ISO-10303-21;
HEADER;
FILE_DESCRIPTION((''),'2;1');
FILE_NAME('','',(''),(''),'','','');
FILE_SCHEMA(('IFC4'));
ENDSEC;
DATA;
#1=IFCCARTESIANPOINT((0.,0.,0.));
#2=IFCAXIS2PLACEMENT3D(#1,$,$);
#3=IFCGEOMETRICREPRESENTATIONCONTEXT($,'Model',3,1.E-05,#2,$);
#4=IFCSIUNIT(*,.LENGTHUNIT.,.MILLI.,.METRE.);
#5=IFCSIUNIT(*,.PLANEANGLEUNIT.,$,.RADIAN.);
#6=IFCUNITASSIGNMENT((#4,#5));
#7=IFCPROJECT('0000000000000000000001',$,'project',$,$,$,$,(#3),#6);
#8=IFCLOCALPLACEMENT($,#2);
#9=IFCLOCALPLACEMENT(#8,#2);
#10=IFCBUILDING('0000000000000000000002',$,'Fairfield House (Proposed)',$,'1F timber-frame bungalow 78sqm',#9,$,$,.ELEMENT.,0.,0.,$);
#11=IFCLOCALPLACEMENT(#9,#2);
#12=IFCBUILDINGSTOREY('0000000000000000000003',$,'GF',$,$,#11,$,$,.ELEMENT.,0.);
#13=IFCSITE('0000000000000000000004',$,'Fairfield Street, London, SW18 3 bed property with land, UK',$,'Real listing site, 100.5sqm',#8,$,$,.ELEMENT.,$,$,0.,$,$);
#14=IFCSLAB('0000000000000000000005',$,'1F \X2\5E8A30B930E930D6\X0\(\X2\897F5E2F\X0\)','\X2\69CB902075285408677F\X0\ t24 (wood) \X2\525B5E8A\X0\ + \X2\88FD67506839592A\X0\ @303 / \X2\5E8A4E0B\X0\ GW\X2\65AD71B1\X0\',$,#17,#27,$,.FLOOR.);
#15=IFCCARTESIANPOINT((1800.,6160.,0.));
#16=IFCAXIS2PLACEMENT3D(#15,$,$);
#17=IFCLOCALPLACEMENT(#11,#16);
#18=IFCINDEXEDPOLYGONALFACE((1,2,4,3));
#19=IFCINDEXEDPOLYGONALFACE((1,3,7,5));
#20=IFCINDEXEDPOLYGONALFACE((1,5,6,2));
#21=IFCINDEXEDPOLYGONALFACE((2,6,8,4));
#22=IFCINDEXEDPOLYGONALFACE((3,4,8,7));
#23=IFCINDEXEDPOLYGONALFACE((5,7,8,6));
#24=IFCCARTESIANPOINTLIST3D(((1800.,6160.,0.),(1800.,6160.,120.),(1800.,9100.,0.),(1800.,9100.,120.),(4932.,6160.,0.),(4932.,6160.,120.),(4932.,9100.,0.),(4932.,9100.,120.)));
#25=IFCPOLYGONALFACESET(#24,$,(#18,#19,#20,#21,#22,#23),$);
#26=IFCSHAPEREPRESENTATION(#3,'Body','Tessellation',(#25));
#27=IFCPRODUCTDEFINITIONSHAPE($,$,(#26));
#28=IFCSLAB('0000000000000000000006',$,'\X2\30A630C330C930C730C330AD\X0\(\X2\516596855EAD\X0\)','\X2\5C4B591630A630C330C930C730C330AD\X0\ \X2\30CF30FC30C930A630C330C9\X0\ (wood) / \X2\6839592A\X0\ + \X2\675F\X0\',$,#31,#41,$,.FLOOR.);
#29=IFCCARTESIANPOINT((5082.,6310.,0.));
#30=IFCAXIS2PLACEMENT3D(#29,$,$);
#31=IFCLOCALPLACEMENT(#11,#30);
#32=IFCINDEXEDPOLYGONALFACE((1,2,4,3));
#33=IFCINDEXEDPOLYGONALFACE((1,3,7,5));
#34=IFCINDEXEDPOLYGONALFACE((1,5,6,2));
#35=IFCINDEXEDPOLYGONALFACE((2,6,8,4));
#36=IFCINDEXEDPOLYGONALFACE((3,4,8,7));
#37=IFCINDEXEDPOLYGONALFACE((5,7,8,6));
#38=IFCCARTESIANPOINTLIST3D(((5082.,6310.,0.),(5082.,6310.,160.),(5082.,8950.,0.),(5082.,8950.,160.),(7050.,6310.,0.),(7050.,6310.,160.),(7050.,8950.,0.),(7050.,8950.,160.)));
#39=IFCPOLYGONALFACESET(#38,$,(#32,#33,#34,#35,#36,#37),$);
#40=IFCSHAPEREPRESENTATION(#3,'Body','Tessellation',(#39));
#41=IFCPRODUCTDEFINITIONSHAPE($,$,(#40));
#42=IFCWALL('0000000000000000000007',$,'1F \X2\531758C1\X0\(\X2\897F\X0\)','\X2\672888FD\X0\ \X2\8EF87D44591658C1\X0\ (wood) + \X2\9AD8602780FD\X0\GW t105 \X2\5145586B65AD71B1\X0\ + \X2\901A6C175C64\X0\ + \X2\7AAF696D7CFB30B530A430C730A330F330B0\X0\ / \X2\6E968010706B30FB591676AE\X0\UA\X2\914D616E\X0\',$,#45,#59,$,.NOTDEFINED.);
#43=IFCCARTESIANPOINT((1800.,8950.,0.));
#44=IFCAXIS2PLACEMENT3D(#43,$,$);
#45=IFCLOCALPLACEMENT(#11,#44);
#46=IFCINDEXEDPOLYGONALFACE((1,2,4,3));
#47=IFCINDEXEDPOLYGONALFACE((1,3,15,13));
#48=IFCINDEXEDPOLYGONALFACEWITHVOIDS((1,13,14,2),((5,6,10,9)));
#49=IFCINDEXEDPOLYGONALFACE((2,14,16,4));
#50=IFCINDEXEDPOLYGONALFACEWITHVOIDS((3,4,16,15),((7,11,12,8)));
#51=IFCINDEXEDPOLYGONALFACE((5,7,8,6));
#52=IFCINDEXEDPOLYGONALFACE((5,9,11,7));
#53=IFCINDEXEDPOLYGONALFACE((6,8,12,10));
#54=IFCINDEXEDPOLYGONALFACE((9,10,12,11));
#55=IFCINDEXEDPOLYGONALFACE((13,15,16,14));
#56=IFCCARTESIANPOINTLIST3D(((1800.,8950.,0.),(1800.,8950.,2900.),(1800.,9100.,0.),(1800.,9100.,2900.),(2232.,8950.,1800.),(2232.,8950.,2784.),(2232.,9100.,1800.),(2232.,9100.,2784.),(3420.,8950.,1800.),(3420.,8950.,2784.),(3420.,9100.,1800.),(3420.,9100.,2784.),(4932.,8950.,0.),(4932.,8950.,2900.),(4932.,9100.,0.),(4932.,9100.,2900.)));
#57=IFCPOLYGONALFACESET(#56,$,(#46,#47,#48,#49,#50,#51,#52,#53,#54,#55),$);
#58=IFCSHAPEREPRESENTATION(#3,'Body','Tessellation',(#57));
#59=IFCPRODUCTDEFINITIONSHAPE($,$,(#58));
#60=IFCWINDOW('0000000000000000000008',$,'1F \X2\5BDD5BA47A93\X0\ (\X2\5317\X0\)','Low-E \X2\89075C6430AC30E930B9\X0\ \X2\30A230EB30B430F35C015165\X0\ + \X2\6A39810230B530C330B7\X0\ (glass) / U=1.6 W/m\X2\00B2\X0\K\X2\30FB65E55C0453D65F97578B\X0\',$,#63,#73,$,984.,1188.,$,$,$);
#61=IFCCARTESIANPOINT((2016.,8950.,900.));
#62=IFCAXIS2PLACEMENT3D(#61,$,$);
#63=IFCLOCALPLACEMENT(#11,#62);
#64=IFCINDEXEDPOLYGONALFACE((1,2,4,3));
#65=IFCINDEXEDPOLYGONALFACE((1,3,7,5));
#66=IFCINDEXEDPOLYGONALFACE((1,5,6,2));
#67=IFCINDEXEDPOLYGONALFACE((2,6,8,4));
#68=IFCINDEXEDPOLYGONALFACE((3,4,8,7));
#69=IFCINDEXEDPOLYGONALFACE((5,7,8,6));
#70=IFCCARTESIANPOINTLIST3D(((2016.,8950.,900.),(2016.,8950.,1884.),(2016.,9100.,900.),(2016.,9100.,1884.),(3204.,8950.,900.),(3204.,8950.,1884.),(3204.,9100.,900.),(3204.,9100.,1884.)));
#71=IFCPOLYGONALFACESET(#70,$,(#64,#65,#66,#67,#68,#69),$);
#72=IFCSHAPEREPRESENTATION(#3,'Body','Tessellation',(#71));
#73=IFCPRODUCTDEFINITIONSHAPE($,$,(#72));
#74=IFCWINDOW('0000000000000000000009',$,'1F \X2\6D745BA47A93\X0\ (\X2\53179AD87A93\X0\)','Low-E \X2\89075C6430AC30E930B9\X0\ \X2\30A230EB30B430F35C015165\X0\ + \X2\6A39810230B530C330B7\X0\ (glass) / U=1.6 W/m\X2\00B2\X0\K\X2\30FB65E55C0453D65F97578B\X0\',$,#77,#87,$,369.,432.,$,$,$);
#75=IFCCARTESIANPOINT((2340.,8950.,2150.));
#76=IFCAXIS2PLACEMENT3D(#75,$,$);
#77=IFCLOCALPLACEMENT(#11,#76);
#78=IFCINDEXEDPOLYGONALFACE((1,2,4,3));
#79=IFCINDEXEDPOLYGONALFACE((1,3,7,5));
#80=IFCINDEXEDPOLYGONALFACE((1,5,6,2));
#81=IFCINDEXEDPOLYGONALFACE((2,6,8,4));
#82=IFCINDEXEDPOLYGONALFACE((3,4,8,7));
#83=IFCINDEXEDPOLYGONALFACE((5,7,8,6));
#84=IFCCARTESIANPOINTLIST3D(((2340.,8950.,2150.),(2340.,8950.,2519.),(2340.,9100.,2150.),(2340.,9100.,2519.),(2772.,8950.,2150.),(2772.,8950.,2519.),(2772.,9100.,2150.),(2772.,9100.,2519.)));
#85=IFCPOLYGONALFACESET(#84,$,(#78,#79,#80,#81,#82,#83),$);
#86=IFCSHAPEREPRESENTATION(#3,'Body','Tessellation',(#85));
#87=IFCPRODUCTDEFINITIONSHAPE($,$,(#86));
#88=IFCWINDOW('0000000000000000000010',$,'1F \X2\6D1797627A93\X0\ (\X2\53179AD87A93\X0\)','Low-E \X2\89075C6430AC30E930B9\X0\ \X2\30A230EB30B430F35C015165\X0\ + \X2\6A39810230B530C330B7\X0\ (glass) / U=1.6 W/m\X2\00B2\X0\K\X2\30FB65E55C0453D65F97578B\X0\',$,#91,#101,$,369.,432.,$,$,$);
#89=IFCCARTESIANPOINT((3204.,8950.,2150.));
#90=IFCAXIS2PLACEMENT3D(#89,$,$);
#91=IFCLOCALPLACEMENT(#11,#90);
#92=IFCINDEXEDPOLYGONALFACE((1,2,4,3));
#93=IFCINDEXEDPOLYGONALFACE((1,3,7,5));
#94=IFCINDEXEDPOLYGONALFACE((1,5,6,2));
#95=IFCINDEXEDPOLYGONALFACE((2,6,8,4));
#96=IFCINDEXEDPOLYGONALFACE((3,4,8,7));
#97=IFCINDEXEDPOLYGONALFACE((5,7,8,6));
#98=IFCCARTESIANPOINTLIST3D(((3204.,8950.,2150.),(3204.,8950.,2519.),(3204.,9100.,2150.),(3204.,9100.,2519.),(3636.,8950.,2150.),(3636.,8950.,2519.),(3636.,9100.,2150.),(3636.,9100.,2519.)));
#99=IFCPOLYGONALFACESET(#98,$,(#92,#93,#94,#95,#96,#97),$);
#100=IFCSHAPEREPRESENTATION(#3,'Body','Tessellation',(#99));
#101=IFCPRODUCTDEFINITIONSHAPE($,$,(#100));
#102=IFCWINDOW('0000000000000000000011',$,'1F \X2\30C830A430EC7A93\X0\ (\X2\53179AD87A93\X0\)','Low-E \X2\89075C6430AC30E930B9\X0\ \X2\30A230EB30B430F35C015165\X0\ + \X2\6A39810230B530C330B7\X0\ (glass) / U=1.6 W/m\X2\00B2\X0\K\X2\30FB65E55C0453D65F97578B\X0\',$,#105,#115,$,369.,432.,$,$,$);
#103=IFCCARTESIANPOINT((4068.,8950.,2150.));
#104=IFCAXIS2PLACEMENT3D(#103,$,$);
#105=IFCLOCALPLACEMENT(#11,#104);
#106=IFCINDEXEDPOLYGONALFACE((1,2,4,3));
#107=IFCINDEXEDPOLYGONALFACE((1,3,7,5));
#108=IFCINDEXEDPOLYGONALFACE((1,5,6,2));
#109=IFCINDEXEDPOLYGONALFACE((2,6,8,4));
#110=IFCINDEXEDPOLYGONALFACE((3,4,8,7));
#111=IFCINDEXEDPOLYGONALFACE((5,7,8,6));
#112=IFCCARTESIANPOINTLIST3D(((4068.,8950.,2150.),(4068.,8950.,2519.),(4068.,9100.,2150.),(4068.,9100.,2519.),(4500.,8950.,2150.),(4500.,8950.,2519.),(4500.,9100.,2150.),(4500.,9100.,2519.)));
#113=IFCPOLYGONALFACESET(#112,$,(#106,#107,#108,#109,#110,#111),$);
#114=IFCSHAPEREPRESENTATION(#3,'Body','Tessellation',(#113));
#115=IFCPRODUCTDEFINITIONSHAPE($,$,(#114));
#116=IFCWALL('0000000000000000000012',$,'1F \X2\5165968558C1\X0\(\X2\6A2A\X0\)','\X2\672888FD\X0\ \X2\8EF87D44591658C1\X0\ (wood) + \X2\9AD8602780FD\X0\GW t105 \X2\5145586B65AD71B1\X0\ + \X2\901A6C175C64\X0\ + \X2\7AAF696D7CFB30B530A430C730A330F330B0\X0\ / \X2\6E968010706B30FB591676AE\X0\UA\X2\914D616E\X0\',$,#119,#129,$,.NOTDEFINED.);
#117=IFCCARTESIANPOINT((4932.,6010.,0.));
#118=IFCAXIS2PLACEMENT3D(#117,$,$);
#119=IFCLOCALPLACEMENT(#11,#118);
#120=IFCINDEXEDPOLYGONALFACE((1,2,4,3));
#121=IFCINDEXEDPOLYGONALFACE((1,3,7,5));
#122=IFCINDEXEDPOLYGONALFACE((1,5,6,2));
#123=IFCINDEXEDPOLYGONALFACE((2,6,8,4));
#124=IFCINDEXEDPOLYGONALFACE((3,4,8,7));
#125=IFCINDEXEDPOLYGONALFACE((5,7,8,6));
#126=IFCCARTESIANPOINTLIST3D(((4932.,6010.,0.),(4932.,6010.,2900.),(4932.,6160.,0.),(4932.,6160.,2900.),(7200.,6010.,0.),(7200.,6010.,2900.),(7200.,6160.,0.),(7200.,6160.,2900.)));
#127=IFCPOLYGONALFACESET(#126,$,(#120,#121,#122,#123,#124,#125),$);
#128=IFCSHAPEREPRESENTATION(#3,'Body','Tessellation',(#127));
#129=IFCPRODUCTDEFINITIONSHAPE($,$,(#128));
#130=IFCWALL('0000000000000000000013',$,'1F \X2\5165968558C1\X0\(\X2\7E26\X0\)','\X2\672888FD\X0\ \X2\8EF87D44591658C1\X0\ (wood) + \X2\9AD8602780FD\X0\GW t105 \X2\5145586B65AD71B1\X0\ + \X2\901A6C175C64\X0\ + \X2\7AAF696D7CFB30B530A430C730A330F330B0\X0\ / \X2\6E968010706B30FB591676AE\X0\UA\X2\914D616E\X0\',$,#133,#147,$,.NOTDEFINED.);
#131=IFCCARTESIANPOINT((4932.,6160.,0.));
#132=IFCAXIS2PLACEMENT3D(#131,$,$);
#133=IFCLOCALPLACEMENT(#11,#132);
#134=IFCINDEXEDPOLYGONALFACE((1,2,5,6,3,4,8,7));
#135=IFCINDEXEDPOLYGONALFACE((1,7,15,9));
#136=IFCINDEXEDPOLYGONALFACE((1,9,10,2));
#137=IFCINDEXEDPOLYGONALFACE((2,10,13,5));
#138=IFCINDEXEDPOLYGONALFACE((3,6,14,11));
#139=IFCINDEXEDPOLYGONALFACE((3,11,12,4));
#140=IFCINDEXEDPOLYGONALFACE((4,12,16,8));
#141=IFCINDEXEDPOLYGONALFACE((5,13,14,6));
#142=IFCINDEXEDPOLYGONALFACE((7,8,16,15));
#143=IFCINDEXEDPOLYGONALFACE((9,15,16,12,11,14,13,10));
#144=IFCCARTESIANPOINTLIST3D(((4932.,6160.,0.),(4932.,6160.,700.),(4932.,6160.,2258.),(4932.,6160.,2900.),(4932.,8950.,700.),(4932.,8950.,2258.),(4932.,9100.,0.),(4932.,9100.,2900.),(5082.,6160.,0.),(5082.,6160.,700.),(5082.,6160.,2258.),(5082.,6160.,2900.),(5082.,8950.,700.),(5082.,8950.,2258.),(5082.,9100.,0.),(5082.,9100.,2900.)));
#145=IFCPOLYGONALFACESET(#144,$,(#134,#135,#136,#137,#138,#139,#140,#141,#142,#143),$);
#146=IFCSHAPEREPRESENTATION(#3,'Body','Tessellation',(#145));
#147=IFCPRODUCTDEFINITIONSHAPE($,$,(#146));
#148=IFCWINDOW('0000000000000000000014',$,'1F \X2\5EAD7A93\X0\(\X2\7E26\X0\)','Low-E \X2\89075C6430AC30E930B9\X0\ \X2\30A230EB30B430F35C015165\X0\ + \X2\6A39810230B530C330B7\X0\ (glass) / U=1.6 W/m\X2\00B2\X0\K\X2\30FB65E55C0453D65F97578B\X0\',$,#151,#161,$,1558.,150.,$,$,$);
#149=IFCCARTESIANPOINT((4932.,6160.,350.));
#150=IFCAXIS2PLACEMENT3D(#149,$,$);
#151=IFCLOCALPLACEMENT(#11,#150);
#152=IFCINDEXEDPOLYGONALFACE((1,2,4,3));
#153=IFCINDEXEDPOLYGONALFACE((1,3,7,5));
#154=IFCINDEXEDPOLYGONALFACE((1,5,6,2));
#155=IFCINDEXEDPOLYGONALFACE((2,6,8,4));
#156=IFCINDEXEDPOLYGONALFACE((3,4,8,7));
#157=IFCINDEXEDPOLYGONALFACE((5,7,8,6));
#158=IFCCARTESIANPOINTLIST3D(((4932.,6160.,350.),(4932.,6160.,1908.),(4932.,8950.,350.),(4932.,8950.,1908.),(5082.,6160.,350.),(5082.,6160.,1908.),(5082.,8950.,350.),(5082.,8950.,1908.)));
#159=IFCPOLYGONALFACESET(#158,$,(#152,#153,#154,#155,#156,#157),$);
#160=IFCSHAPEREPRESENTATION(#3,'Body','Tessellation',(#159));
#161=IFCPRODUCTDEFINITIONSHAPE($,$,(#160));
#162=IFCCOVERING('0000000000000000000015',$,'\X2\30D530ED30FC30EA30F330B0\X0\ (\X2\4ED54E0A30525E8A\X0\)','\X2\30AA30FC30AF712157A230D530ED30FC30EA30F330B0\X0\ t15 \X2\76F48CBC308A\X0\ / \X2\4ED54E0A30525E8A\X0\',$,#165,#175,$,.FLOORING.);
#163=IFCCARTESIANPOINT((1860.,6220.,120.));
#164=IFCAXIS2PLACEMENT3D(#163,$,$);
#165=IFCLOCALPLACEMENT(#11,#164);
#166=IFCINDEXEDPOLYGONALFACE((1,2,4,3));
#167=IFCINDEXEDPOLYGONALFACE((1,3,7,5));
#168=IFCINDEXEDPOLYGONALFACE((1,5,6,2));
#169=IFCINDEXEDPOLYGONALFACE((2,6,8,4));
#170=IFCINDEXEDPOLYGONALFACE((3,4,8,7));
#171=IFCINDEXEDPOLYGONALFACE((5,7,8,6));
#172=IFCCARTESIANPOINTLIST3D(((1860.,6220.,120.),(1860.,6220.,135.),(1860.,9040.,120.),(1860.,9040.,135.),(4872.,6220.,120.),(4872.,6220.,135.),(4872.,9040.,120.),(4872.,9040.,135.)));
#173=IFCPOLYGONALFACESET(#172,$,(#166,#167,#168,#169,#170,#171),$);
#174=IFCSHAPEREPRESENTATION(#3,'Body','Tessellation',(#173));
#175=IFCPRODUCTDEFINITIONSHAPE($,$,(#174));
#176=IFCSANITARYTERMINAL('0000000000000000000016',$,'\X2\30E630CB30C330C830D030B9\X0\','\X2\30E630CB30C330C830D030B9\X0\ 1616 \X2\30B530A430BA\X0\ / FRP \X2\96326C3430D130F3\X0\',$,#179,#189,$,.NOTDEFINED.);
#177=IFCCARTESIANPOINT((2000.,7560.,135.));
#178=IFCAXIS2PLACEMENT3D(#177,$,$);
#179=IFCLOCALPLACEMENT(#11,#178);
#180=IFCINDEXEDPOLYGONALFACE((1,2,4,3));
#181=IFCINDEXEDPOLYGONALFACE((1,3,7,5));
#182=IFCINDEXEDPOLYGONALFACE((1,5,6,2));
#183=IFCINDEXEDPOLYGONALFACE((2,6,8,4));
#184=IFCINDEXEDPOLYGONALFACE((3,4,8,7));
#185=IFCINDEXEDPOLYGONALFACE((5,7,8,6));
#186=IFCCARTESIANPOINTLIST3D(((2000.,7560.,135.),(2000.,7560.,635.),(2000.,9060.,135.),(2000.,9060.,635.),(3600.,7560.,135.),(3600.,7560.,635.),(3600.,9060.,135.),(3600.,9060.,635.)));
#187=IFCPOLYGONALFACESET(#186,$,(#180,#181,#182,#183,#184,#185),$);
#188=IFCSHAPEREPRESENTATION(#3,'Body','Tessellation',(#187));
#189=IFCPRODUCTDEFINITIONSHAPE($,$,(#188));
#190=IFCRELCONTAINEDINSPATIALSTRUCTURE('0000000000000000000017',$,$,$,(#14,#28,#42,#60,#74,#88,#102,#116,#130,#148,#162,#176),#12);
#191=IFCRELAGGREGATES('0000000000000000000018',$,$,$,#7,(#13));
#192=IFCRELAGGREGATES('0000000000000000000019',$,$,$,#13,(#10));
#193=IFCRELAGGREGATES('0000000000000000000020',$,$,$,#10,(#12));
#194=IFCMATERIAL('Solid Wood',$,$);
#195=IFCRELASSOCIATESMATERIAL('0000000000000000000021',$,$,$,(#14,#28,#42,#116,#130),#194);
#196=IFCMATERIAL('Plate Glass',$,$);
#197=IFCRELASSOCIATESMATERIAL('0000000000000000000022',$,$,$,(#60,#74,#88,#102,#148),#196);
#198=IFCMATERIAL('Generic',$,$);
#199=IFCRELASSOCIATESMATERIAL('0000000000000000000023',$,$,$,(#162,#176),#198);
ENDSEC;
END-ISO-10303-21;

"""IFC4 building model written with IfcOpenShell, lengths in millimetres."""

from ifc_helpers import new_model, si_unit, frame, frame_2d, origin, place, context, project, spatial, rectangle, extrude, material, element, fill, save


model = new_model("IFC4")

# Units and contexts
model_context = context("Model", 3, precision=1e-05, world=origin())
ifc_project = project(units=[si_unit("LENGTHUNIT", "METRE", prefix="MILLI"), si_unit("PLANEANGLEUNIT", "RADIAN")], contexts=[model_context])

# Site, building, storey
site_placement = place(None, origin())
site = spatial("IfcSite", under=ifc_project, at=site_placement, Name="Fairfield Street, London, SW18 3 bed property with land, UK", ObjectType="Real listing site, 100.5sqm", CompositionType="ELEMENT", RefElevation=0.0)
building_placement = place(site_placement, origin())
building = spatial("IfcBuilding", under=site, at=building_placement, Name="Fairfield House (Proposed)", ObjectType="1F timber-frame bungalow 78sqm", CompositionType="ELEMENT", ElevationOfRefHeight=0.0, ElevationOfTerrain=0.0)
storey_placement = place(building_placement, origin())
storey = spatial("IfcBuildingStorey", under=building, at=storey_placement, Name="GF", CompositionType="ELEMENT", Elevation=0.0)

# Slabs
ifc_material_1 = material(Name="Solid Wood")
slab_1_placement = place(storey_placement, frame((1800.0, 6160.0, 0.0)))
element("IfcSlab", 1, at=slab_1_placement, inside=storey, material=ifc_material_1, Name="1F 床スラブ(西帯)", Description="構造用合板 t24 (wood) 剛床 + 製材根太 @303 / 床下 GW断熱", PredefinedType="FLOOR", context=model_context, shape_type="SweptSolid", body=[
    extrude(rectangle(XDim=3132.0, YDim=2940.0, at=frame_2d((1566.0, 1470.0))), frame((1800.0, 6160.0, 0.0)), (0.0, 0.0, 1.0), 120.0),
])
slab_2_placement = place(storey_placement, frame((5082.0, 6310.0, 0.0)))
element("IfcSlab", 2, at=slab_2_placement, inside=storey, material=ifc_material_1, Name="ウッドデッキ(入隅庭)", Description="屋外ウッドデッキ ハードウッド (wood) / 根太 + 束", PredefinedType="FLOOR", context=model_context, shape_type="SweptSolid", body=[
    extrude(rectangle(XDim=1968.0, YDim=2640.0, at=frame_2d((984.0, 1320.0))), frame((5082.0, 6310.0, 0.0)), (0.0, 0.0, 1.0), 160.0),
])

# Wall, openings, windows
wall_1_placement = place(storey_placement, frame((1800.0, 8950.0, 0.0)))
wall_1 = element("IfcWall", 3, at=wall_1_placement, inside=storey, material=ifc_material_1, Name="1F 北壁(西)", Description="木製 軸組外壁 (wood) + 高性能GW t105 充填断熱 + 通気層 + 窯業系サイディング / 準耐火・外皮UA配慮", PredefinedType="NOTDEFINED", context=model_context, shape_type="SweptSolid", body=[
    extrude(rectangle(XDim=3132.0, YDim=150.0, at=frame_2d((1566.0, 75.0))), frame((1800.0, 8950.0, 0.0)), (0.0, 0.0, 1.0), 2900.0),
])
opening_1_placement = place(storey_placement, frame((2016.0, 8950.0, 900.0)))
opening_1 = element("IfcOpeningElement", 4, at=opening_1_placement, cuts=wall_1, PredefinedType="NOTDEFINED", context=model_context, shape_type="SweptSolid", body=[
    extrude(rectangle(XDim=1188.0, YDim=150.0, at=frame_2d((594.0, 75.0))), frame((2016.0, 8950.0, 900.0)), (0.0, 0.0, 1.0), 984.0),
])
opening_2_placement = place(storey_placement, frame((2340.0, 8950.0, 2150.0)))
opening_2 = element("IfcOpeningElement", 5, at=opening_2_placement, cuts=wall_1, PredefinedType="NOTDEFINED", context=model_context, shape_type="SweptSolid", body=[
    extrude(rectangle(XDim=432.0, YDim=150.0, at=frame_2d((216.0, 75.0))), frame((2340.0, 8950.0, 2150.0)), (0.0, 0.0, 1.0), 369.0),
])
opening_3_placement = place(storey_placement, frame((3204.0, 8950.0, 2150.0)))
opening_3 = element("IfcOpeningElement", 6, at=opening_3_placement, cuts=wall_1, PredefinedType="NOTDEFINED", context=model_context, shape_type="SweptSolid", body=[
    extrude(rectangle(XDim=432.0, YDim=150.0, at=frame_2d((216.0, 75.0))), frame((3204.0, 8950.0, 2150.0)), (0.0, 0.0, 1.0), 369.0),
])
opening_4_placement = place(storey_placement, frame((4068.0, 8950.0, 2150.0)))
opening_4 = element("IfcOpeningElement", 7, at=opening_4_placement, cuts=wall_1, PredefinedType="NOTDEFINED", context=model_context, shape_type="SweptSolid", body=[
    extrude(rectangle(XDim=432.0, YDim=150.0, at=frame_2d((216.0, 75.0))), frame((4068.0, 8950.0, 2150.0)), (0.0, 0.0, 1.0), 369.0),
])
ifc_material_2 = material(Name="Plate Glass")
window_1_placement = place(storey_placement, frame((2016.0, 8950.0, 900.0)))
window_1 = element("IfcWindow", 8, at=window_1_placement, inside=storey, material=ifc_material_2, Name="1F 寝室窓 (北)", Description="Low-E 複層ガラス アルゴン封入 + 樹脂サッシ (glass) / U=1.6 W/m²K・日射取得型", OverallHeight=984.0, OverallWidth=1188.0, context=model_context, shape_type="SweptSolid", body=[
    extrude(rectangle(XDim=1188.0, YDim=150.0, at=frame_2d((594.0, 75.0))), frame((2016.0, 8950.0, 900.0)), (0.0, 0.0, 1.0), 984.0),
])
fill(opening_1, window_1)
window_2_placement = place(storey_placement, frame((2340.0, 8950.0, 2150.0)))
window_2 = element("IfcWindow", 9, at=window_2_placement, inside=storey, material=ifc_material_2, Name="1F 浴室窓 (北高窓)", Description="Low-E 複層ガラス アルゴン封入 + 樹脂サッシ (glass) / U=1.6 W/m²K・日射取得型", OverallHeight=369.0, OverallWidth=432.0, context=model_context, shape_type="SweptSolid", body=[
    extrude(rectangle(XDim=432.0, YDim=150.0, at=frame_2d((216.0, 75.0))), frame((2340.0, 8950.0, 2150.0)), (0.0, 0.0, 1.0), 369.0),
])
fill(opening_2, window_2)
window_3_placement = place(storey_placement, frame((3204.0, 8950.0, 2150.0)))
window_3 = element("IfcWindow", 10, at=window_3_placement, inside=storey, material=ifc_material_2, Name="1F 洗面窓 (北高窓)", Description="Low-E 複層ガラス アルゴン封入 + 樹脂サッシ (glass) / U=1.6 W/m²K・日射取得型", OverallHeight=369.0, OverallWidth=432.0, context=model_context, shape_type="SweptSolid", body=[
    extrude(rectangle(XDim=432.0, YDim=150.0, at=frame_2d((216.0, 75.0))), frame((3204.0, 8950.0, 2150.0)), (0.0, 0.0, 1.0), 369.0),
])
fill(opening_3, window_3)
window_4_placement = place(storey_placement, frame((4068.0, 8950.0, 2150.0)))
window_4 = element("IfcWindow", 11, at=window_4_placement, inside=storey, material=ifc_material_2, Name="1F トイレ窓 (北高窓)", Description="Low-E 複層ガラス アルゴン封入 + 樹脂サッシ (glass) / U=1.6 W/m²K・日射取得型", OverallHeight=369.0, OverallWidth=432.0, context=model_context, shape_type="SweptSolid", body=[
    extrude(rectangle(XDim=432.0, YDim=150.0, at=frame_2d((216.0, 75.0))), frame((4068.0, 8950.0, 2150.0)), (0.0, 0.0, 1.0), 369.0),
])
fill(opening_4, window_4)

# Wall
wall_2_placement = place(storey_placement, frame((4932.0, 6010.0, 0.0)))
element("IfcWall", 12, at=wall_2_placement, inside=storey, material=ifc_material_1, Name="1F 入隅壁(横)", Description="木製 軸組外壁 (wood) + 高性能GW t105 充填断熱 + 通気層 + 窯業系サイディング / 準耐火・外皮UA配慮", PredefinedType="NOTDEFINED", context=model_context, shape_type="SweptSolid", body=[
    extrude(rectangle(XDim=2268.0, YDim=150.0, at=frame_2d((1134.0, 75.0))), frame((4932.0, 6010.0, 0.0)), (0.0, 0.0, 1.0), 2900.0),
])

# Wall, opening, window
wall_3_placement = place(storey_placement, frame((4932.0, 6160.0, 0.0)))
wall_3 = element("IfcWall", 13, at=wall_3_placement, inside=storey, material=ifc_material_1, Name="1F 入隅壁(縦)", Description="木製 軸組外壁 (wood) + 高性能GW t105 充填断熱 + 通気層 + 窯業系サイディング / 準耐火・外皮UA配慮", PredefinedType="NOTDEFINED", context=model_context, shape_type="SweptSolid", body=[
    extrude(rectangle(XDim=150.0, YDim=2940.0, at=frame_2d((75.0, 1470.0))), frame((4932.0, 6160.0, 0.0)), (0.0, 0.0, 1.0), 2900.0),
])
opening_5_placement = place(storey_placement, frame((4932.0, 6160.0, 350.0)))
opening_5 = element("IfcOpeningElement", 14, at=opening_5_placement, cuts=wall_3, PredefinedType="NOTDEFINED", context=model_context, shape_type="SweptSolid", body=[
    extrude(rectangle(XDim=150.0, YDim=2790.0, at=frame_2d((75.0, 1395.0))), frame((4932.0, 6160.0, 350.0)), (0.0, 0.0, 1.0), 1558.0),
])
window_5_placement = place(storey_placement, frame((4932.0, 6160.0, 350.0)))
window_5 = element("IfcWindow", 15, at=window_5_placement, inside=storey, material=ifc_material_2, Name="1F 庭窓(縦)", Description="Low-E 複層ガラス アルゴン封入 + 樹脂サッシ (glass) / U=1.6 W/m²K・日射取得型", OverallHeight=1558.0, OverallWidth=150.0, context=model_context, shape_type="SweptSolid", body=[
    extrude(rectangle(XDim=150.0, YDim=2790.0, at=frame_2d((75.0, 1395.0))), frame((4932.0, 6160.0, 350.0)), (0.0, 0.0, 1.0), 1558.0),
])
fill(opening_5, window_5)

# Covering
ifc_material_3 = material(Name="Generic")
covering_placement = place(storey_placement, frame((1860.0, 6220.0, 120.0)))
element("IfcCovering", 16, at=covering_placement, inside=storey, material=ifc_material_3, Name="フローリング (仕上げ床)", Description="オーク無垢フローリング t15 直貼り / 仕上げ床", PredefinedType="FLOORING", context=model_context, shape_type="SweptSolid", body=[
    extrude(rectangle(XDim=3012.0, YDim=2820.0, at=frame_2d((1506.0, 1410.0))), frame((1860.0, 6220.0, 120.0)), (0.0, 0.0, 1.0), 15.0),
])

# Sanitary terminal
sanitary_terminal_1_placement = place(storey_placement, frame((2000.0, 7560.0, 135.0)))
element("IfcSanitaryTerminal", 17, at=sanitary_terminal_1_placement, inside=storey, material=ifc_material_3, Name="ユニットバス", Description="ユニットバス 1616 サイズ / FRP 防水パン", PredefinedType="NOTDEFINED", context=model_context, shape_type="SweptSolid", body=[
    extrude(rectangle(XDim=1600.0, YDim=1500.0, at=frame_2d((800.0, 750.0))), frame((2000.0, 7560.0, 135.0)), (0.0, 0.0, 1.0), 500.0),
])

save(model, "model.ifc")
